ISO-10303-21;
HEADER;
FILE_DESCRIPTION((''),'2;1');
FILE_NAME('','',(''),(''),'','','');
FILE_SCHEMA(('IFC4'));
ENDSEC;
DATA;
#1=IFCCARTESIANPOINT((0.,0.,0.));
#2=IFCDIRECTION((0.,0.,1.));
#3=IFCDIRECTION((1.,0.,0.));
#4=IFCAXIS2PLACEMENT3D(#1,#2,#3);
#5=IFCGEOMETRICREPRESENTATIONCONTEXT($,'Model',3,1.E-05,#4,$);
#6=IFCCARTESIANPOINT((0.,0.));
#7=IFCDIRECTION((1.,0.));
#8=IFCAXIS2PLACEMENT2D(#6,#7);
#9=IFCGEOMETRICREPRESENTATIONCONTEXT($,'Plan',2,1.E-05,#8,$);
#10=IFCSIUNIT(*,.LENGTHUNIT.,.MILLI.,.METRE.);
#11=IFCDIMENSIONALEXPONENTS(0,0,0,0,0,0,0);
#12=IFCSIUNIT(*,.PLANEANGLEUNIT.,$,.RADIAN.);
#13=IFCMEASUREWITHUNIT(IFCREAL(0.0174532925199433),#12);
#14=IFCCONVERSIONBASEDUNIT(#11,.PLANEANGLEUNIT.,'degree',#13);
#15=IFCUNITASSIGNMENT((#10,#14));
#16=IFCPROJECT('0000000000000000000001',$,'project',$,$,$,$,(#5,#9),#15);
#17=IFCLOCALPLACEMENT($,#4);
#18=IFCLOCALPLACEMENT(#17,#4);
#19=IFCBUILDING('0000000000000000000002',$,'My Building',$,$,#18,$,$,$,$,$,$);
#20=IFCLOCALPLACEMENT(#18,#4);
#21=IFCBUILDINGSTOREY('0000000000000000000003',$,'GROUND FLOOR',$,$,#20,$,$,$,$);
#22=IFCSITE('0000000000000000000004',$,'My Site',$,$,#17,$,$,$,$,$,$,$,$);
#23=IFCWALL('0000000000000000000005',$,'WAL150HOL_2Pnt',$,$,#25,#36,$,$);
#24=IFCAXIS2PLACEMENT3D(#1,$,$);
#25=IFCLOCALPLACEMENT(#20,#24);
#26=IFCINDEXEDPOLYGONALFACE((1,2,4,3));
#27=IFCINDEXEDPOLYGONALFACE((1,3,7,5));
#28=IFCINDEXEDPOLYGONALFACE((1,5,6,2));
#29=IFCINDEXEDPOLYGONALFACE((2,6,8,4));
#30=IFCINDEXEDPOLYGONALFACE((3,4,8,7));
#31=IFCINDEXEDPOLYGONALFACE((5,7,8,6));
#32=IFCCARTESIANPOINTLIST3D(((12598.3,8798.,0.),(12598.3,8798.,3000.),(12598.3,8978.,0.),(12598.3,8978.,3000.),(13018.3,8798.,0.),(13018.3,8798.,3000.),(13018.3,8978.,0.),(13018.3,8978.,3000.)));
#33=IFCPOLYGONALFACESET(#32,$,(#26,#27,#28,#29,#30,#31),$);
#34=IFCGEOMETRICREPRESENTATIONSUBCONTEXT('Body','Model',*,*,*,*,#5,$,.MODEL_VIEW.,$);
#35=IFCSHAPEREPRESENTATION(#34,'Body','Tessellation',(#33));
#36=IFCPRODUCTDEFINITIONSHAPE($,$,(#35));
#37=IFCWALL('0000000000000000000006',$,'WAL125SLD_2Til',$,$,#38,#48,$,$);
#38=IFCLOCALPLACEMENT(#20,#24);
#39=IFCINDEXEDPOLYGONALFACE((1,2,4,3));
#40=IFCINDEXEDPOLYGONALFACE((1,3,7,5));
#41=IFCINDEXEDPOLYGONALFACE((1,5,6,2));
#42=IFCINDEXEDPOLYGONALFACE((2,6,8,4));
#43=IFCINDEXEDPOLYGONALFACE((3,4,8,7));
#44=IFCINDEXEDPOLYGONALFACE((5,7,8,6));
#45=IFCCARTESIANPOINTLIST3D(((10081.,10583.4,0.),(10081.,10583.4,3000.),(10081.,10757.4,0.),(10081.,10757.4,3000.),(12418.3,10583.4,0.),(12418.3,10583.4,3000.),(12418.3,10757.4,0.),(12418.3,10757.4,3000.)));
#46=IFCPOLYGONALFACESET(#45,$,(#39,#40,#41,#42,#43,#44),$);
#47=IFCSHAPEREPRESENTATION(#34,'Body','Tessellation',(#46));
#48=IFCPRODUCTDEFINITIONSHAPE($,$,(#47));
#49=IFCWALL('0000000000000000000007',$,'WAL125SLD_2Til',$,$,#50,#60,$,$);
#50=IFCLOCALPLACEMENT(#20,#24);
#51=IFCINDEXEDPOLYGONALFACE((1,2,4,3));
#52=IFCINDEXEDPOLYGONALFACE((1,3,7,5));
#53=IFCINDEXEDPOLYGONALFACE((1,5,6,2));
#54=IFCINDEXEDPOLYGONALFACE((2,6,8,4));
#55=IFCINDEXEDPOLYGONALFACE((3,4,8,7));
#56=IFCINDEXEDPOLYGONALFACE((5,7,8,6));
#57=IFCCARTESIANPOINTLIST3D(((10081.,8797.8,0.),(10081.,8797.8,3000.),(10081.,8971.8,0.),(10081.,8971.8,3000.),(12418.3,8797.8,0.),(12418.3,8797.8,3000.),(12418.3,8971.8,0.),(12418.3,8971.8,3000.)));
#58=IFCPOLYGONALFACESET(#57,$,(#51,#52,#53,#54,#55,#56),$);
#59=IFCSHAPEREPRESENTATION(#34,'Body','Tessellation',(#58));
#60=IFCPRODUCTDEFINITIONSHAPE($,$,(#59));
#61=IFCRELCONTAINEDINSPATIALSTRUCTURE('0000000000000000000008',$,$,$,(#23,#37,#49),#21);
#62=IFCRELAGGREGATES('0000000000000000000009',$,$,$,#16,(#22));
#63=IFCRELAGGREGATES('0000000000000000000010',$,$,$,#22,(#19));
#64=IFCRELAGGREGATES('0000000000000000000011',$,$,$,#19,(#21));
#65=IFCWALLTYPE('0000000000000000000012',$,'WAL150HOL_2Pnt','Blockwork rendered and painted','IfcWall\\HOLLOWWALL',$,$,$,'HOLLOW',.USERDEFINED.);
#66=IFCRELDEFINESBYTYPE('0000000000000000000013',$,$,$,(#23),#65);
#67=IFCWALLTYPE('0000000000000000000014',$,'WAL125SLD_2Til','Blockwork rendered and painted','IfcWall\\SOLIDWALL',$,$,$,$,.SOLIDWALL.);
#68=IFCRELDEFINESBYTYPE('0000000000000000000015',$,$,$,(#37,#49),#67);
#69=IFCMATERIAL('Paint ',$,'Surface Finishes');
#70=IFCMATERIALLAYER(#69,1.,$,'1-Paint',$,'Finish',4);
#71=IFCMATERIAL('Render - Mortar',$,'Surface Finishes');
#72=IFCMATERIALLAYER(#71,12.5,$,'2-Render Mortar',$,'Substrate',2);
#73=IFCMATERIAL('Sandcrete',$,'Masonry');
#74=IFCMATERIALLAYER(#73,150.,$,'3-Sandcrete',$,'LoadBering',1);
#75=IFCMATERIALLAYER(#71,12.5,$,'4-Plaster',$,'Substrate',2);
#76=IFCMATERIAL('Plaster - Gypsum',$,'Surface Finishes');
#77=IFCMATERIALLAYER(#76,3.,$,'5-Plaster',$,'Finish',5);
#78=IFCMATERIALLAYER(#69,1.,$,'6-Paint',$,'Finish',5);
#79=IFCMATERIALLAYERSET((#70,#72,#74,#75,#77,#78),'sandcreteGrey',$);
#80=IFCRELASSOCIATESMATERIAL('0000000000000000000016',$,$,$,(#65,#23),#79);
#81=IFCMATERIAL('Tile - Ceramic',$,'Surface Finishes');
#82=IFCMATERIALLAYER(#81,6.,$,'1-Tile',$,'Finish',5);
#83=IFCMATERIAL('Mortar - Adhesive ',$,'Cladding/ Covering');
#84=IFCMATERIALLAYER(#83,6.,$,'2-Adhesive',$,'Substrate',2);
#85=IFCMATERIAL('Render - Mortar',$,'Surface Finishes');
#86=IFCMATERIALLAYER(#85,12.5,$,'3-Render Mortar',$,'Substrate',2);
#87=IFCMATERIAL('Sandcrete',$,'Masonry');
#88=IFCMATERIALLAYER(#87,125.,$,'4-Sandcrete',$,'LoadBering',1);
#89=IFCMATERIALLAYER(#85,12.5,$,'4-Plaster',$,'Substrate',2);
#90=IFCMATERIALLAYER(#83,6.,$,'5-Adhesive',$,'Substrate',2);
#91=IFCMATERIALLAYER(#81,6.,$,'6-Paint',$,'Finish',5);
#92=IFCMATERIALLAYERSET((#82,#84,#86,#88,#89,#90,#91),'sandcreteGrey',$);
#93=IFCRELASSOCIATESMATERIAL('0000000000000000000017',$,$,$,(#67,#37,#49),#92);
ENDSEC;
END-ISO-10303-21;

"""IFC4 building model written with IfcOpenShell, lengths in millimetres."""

from ifc_helpers import new_model, entity, si_unit, converted_unit, frame, origin_with_axes, origin_2d_with_axis, place, context, subcontext, project, spatial, indexed_curve, outline, extrude, material, layer, layer_set, layer_usage, type_object, element, save


model = new_model("IFC4")

# Units and contexts
model_context = context("Model", 3, precision=1e-05, world=origin_with_axes())
plan_context = context("Plan", 2, precision=1e-05, world=origin_2d_with_axis())
body_context_1 = subcontext(model_context, "Body", "Model", "MODEL_VIEW")
ifc_project = project(units=[si_unit("LENGTHUNIT", "METRE", prefix="MILLI"), converted_unit("PLANEANGLEUNIT", "degree", entity("IfcReal", 0.0174532925199433), si_unit("PLANEANGLEUNIT", "RADIAN"), dimensions=[0, 0, 0, 0, 0, 0, 0])], contexts=[model_context, plan_context])

# Site, building, storey
site_placement = place(None, origin_with_axes())
site = spatial("IfcSite", under=ifc_project, at=site_placement, Name="My Site")
building_placement = place(site_placement, origin_with_axes())
building = spatial("IfcBuilding", under=site, at=building_placement, Name="My Building")
storey_placement = place(building_placement, origin_with_axes())
storey = spatial("IfcBuildingStorey", under=building, at=storey_placement, Name="GROUND FLOOR")

# Shared definitions
ifc_material_1 = material(Name="Paint ", Category="Surface Finishes")
ifc_layer_1 = layer(ifc_material_1, 1.0, Name="1-Paint", Category="Finish", Priority=4)
ifc_material_2 = material(Name="Render - Mortar", Category="Surface Finishes")
ifc_layer_2 = layer(ifc_material_2, 12.5, Name="2-Render Mortar", Category="Substrate", Priority=2)
ifc_material_3 = material(Name="Sandcrete", Category="Masonry")
ifc_layer_3 = layer(ifc_material_3, 150.0, Name="3-Sandcrete", Category="LoadBering", Priority=1)
ifc_layer_4 = layer(ifc_material_2, 12.5, Name="4-Plaster", Category="Substrate", Priority=2)
ifc_material_4 = material(Name="Plaster - Gypsum", Category="Surface Finishes")
ifc_layer_5 = layer(ifc_material_4, 3.0, Name="5-Plaster", Category="Finish", Priority=5)
ifc_layer_6 = layer(ifc_material_1, 1.0, Name="6-Paint", Category="Finish", Priority=5)
ifc_layer_set_1 = layer_set([ifc_layer_1, ifc_layer_2, ifc_layer_3, ifc_layer_4, ifc_layer_5, ifc_layer_6], Name="sandcreteGrey")
wall_type_1 = type_object("IfcWallType", Name="WAL150HOL_2Pnt", Description="Blockwork rendered and painted", ApplicableOccurrence="IfcWall\\HOLLOWWALL", ElementType="HOLLOW", PredefinedType="USERDEFINED", material=ifc_layer_set_1)

# Walls
ifc_layer_usage_1 = layer_usage(ifc_layer_set_1, "AXIS2", "POSITIVE", 0.0)
wall_1_placement = place(storey_placement, frame((13018.3, 8978.0, 0.0), z_axis=(0.0, 0.0, 1.0), x_axis=(-1.0, 0.000001, 0.0)))
element("IfcWall", 1, at=wall_1_placement, inside=storey, type_object=wall_type_1, material=ifc_layer_usage_1, Name="WAL150HOL_2Pnt", context=body_context_1, shape_type="SweptSolid", body=[
    extrude(outline(indexed_curve([(0.0, 0.0), (0.0, 180.0), (420.0, 180.0), (420.0, 0.0), (0.0, 0.0)], self_intersect=False)), origin_with_axes(), (0.0, 0.0, 1.0), 3000.0),
])
ifc_material_5 = material(Name="Tile - Ceramic", Category="Surface Finishes")
ifc_layer_7 = layer(ifc_material_5, 6.0, Name="1-Tile", Category="Finish", Priority=5)
ifc_material_6 = material(Name="Mortar - Adhesive ", Category="Cladding/ Covering")
ifc_layer_8 = layer(ifc_material_6, 6.0, Name="2-Adhesive", Category="Substrate", Priority=2)
ifc_material_7 = material(Name="Render - Mortar", Category="Surface Finishes")
ifc_layer_9 = layer(ifc_material_7, 12.5, Name="3-Render Mortar", Category="Substrate", Priority=2)
ifc_material_8 = material(Name="Sandcrete", Category="Masonry")
ifc_layer_10 = layer(ifc_material_8, 125.0, Name="4-Sandcrete", Category="LoadBering", Priority=1)
ifc_layer_11 = layer(ifc_material_7, 12.5, Name="4-Plaster", Category="Substrate", Priority=2)
ifc_layer_12 = layer(ifc_material_6, 6.0, Name="5-Adhesive", Category="Substrate", Priority=2)
ifc_layer_13 = layer(ifc_material_5, 6.0, Name="6-Paint", Category="Finish", Priority=5)
ifc_layer_set_2 = layer_set([ifc_layer_7, ifc_layer_8, ifc_layer_9, ifc_layer_10, ifc_layer_11, ifc_layer_12, ifc_layer_13], Name="sandcreteGrey")
ifc_layer_usage_2 = layer_usage(ifc_layer_set_2, "AXIS2", "POSITIVE", 0.0)
wall_type_2 = type_object("IfcWallType", Name="WAL125SLD_2Til", Description="Blockwork rendered and painted", ApplicableOccurrence="IfcWall\\SOLIDWALL", PredefinedType="SOLIDWALL", material=ifc_layer_set_2)
wall_2_placement = place(storey_placement, frame((10081.0, 10583.4, 0.0), z_axis=(0.0, 0.0, 1.0), x_axis=(1.0, -0.000001, 0.0)))
element("IfcWall", 2, at=wall_2_placement, inside=storey, type_object=wall_type_2, material=ifc_layer_usage_2, Name="WAL125SLD_2Til", context=body_context_1, shape_type="SweptSolid", body=[
    extrude(outline(indexed_curve([(0.0, 0.0), (0.0, 174.0), (2337.3, 174.0), (2337.3, 0.0), (0.0, 0.0)], self_intersect=False)), origin_with_axes(), (0.0, 0.0, 1.0), 3000.0),
])
ifc_layer_usage_3 = layer_usage(ifc_layer_set_2, "AXIS2", "POSITIVE", 0.0)
wall_3_placement = place(storey_placement, frame((10081.0, 8797.8, 0.0), z_axis=(0.0, 0.0, 1.0), x_axis=(1.0, -0.000001, 0.0)))
element("IfcWall", 3, at=wall_3_placement, inside=storey, type_object=wall_type_2, material=ifc_layer_usage_3, Name="WAL125SLD_2Til", context=body_context_1, shape_type="SweptSolid", body=[
    extrude(outline(indexed_curve([(0.0, 0.0), (0.0, 174.0), (2337.3, 174.0), (2337.3, 0.0), (0.0, 0.0)], self_intersect=False)), origin_with_axes(), (0.0, 0.0, 1.0), 3000.0),
])

save(model, "model.ifc")
